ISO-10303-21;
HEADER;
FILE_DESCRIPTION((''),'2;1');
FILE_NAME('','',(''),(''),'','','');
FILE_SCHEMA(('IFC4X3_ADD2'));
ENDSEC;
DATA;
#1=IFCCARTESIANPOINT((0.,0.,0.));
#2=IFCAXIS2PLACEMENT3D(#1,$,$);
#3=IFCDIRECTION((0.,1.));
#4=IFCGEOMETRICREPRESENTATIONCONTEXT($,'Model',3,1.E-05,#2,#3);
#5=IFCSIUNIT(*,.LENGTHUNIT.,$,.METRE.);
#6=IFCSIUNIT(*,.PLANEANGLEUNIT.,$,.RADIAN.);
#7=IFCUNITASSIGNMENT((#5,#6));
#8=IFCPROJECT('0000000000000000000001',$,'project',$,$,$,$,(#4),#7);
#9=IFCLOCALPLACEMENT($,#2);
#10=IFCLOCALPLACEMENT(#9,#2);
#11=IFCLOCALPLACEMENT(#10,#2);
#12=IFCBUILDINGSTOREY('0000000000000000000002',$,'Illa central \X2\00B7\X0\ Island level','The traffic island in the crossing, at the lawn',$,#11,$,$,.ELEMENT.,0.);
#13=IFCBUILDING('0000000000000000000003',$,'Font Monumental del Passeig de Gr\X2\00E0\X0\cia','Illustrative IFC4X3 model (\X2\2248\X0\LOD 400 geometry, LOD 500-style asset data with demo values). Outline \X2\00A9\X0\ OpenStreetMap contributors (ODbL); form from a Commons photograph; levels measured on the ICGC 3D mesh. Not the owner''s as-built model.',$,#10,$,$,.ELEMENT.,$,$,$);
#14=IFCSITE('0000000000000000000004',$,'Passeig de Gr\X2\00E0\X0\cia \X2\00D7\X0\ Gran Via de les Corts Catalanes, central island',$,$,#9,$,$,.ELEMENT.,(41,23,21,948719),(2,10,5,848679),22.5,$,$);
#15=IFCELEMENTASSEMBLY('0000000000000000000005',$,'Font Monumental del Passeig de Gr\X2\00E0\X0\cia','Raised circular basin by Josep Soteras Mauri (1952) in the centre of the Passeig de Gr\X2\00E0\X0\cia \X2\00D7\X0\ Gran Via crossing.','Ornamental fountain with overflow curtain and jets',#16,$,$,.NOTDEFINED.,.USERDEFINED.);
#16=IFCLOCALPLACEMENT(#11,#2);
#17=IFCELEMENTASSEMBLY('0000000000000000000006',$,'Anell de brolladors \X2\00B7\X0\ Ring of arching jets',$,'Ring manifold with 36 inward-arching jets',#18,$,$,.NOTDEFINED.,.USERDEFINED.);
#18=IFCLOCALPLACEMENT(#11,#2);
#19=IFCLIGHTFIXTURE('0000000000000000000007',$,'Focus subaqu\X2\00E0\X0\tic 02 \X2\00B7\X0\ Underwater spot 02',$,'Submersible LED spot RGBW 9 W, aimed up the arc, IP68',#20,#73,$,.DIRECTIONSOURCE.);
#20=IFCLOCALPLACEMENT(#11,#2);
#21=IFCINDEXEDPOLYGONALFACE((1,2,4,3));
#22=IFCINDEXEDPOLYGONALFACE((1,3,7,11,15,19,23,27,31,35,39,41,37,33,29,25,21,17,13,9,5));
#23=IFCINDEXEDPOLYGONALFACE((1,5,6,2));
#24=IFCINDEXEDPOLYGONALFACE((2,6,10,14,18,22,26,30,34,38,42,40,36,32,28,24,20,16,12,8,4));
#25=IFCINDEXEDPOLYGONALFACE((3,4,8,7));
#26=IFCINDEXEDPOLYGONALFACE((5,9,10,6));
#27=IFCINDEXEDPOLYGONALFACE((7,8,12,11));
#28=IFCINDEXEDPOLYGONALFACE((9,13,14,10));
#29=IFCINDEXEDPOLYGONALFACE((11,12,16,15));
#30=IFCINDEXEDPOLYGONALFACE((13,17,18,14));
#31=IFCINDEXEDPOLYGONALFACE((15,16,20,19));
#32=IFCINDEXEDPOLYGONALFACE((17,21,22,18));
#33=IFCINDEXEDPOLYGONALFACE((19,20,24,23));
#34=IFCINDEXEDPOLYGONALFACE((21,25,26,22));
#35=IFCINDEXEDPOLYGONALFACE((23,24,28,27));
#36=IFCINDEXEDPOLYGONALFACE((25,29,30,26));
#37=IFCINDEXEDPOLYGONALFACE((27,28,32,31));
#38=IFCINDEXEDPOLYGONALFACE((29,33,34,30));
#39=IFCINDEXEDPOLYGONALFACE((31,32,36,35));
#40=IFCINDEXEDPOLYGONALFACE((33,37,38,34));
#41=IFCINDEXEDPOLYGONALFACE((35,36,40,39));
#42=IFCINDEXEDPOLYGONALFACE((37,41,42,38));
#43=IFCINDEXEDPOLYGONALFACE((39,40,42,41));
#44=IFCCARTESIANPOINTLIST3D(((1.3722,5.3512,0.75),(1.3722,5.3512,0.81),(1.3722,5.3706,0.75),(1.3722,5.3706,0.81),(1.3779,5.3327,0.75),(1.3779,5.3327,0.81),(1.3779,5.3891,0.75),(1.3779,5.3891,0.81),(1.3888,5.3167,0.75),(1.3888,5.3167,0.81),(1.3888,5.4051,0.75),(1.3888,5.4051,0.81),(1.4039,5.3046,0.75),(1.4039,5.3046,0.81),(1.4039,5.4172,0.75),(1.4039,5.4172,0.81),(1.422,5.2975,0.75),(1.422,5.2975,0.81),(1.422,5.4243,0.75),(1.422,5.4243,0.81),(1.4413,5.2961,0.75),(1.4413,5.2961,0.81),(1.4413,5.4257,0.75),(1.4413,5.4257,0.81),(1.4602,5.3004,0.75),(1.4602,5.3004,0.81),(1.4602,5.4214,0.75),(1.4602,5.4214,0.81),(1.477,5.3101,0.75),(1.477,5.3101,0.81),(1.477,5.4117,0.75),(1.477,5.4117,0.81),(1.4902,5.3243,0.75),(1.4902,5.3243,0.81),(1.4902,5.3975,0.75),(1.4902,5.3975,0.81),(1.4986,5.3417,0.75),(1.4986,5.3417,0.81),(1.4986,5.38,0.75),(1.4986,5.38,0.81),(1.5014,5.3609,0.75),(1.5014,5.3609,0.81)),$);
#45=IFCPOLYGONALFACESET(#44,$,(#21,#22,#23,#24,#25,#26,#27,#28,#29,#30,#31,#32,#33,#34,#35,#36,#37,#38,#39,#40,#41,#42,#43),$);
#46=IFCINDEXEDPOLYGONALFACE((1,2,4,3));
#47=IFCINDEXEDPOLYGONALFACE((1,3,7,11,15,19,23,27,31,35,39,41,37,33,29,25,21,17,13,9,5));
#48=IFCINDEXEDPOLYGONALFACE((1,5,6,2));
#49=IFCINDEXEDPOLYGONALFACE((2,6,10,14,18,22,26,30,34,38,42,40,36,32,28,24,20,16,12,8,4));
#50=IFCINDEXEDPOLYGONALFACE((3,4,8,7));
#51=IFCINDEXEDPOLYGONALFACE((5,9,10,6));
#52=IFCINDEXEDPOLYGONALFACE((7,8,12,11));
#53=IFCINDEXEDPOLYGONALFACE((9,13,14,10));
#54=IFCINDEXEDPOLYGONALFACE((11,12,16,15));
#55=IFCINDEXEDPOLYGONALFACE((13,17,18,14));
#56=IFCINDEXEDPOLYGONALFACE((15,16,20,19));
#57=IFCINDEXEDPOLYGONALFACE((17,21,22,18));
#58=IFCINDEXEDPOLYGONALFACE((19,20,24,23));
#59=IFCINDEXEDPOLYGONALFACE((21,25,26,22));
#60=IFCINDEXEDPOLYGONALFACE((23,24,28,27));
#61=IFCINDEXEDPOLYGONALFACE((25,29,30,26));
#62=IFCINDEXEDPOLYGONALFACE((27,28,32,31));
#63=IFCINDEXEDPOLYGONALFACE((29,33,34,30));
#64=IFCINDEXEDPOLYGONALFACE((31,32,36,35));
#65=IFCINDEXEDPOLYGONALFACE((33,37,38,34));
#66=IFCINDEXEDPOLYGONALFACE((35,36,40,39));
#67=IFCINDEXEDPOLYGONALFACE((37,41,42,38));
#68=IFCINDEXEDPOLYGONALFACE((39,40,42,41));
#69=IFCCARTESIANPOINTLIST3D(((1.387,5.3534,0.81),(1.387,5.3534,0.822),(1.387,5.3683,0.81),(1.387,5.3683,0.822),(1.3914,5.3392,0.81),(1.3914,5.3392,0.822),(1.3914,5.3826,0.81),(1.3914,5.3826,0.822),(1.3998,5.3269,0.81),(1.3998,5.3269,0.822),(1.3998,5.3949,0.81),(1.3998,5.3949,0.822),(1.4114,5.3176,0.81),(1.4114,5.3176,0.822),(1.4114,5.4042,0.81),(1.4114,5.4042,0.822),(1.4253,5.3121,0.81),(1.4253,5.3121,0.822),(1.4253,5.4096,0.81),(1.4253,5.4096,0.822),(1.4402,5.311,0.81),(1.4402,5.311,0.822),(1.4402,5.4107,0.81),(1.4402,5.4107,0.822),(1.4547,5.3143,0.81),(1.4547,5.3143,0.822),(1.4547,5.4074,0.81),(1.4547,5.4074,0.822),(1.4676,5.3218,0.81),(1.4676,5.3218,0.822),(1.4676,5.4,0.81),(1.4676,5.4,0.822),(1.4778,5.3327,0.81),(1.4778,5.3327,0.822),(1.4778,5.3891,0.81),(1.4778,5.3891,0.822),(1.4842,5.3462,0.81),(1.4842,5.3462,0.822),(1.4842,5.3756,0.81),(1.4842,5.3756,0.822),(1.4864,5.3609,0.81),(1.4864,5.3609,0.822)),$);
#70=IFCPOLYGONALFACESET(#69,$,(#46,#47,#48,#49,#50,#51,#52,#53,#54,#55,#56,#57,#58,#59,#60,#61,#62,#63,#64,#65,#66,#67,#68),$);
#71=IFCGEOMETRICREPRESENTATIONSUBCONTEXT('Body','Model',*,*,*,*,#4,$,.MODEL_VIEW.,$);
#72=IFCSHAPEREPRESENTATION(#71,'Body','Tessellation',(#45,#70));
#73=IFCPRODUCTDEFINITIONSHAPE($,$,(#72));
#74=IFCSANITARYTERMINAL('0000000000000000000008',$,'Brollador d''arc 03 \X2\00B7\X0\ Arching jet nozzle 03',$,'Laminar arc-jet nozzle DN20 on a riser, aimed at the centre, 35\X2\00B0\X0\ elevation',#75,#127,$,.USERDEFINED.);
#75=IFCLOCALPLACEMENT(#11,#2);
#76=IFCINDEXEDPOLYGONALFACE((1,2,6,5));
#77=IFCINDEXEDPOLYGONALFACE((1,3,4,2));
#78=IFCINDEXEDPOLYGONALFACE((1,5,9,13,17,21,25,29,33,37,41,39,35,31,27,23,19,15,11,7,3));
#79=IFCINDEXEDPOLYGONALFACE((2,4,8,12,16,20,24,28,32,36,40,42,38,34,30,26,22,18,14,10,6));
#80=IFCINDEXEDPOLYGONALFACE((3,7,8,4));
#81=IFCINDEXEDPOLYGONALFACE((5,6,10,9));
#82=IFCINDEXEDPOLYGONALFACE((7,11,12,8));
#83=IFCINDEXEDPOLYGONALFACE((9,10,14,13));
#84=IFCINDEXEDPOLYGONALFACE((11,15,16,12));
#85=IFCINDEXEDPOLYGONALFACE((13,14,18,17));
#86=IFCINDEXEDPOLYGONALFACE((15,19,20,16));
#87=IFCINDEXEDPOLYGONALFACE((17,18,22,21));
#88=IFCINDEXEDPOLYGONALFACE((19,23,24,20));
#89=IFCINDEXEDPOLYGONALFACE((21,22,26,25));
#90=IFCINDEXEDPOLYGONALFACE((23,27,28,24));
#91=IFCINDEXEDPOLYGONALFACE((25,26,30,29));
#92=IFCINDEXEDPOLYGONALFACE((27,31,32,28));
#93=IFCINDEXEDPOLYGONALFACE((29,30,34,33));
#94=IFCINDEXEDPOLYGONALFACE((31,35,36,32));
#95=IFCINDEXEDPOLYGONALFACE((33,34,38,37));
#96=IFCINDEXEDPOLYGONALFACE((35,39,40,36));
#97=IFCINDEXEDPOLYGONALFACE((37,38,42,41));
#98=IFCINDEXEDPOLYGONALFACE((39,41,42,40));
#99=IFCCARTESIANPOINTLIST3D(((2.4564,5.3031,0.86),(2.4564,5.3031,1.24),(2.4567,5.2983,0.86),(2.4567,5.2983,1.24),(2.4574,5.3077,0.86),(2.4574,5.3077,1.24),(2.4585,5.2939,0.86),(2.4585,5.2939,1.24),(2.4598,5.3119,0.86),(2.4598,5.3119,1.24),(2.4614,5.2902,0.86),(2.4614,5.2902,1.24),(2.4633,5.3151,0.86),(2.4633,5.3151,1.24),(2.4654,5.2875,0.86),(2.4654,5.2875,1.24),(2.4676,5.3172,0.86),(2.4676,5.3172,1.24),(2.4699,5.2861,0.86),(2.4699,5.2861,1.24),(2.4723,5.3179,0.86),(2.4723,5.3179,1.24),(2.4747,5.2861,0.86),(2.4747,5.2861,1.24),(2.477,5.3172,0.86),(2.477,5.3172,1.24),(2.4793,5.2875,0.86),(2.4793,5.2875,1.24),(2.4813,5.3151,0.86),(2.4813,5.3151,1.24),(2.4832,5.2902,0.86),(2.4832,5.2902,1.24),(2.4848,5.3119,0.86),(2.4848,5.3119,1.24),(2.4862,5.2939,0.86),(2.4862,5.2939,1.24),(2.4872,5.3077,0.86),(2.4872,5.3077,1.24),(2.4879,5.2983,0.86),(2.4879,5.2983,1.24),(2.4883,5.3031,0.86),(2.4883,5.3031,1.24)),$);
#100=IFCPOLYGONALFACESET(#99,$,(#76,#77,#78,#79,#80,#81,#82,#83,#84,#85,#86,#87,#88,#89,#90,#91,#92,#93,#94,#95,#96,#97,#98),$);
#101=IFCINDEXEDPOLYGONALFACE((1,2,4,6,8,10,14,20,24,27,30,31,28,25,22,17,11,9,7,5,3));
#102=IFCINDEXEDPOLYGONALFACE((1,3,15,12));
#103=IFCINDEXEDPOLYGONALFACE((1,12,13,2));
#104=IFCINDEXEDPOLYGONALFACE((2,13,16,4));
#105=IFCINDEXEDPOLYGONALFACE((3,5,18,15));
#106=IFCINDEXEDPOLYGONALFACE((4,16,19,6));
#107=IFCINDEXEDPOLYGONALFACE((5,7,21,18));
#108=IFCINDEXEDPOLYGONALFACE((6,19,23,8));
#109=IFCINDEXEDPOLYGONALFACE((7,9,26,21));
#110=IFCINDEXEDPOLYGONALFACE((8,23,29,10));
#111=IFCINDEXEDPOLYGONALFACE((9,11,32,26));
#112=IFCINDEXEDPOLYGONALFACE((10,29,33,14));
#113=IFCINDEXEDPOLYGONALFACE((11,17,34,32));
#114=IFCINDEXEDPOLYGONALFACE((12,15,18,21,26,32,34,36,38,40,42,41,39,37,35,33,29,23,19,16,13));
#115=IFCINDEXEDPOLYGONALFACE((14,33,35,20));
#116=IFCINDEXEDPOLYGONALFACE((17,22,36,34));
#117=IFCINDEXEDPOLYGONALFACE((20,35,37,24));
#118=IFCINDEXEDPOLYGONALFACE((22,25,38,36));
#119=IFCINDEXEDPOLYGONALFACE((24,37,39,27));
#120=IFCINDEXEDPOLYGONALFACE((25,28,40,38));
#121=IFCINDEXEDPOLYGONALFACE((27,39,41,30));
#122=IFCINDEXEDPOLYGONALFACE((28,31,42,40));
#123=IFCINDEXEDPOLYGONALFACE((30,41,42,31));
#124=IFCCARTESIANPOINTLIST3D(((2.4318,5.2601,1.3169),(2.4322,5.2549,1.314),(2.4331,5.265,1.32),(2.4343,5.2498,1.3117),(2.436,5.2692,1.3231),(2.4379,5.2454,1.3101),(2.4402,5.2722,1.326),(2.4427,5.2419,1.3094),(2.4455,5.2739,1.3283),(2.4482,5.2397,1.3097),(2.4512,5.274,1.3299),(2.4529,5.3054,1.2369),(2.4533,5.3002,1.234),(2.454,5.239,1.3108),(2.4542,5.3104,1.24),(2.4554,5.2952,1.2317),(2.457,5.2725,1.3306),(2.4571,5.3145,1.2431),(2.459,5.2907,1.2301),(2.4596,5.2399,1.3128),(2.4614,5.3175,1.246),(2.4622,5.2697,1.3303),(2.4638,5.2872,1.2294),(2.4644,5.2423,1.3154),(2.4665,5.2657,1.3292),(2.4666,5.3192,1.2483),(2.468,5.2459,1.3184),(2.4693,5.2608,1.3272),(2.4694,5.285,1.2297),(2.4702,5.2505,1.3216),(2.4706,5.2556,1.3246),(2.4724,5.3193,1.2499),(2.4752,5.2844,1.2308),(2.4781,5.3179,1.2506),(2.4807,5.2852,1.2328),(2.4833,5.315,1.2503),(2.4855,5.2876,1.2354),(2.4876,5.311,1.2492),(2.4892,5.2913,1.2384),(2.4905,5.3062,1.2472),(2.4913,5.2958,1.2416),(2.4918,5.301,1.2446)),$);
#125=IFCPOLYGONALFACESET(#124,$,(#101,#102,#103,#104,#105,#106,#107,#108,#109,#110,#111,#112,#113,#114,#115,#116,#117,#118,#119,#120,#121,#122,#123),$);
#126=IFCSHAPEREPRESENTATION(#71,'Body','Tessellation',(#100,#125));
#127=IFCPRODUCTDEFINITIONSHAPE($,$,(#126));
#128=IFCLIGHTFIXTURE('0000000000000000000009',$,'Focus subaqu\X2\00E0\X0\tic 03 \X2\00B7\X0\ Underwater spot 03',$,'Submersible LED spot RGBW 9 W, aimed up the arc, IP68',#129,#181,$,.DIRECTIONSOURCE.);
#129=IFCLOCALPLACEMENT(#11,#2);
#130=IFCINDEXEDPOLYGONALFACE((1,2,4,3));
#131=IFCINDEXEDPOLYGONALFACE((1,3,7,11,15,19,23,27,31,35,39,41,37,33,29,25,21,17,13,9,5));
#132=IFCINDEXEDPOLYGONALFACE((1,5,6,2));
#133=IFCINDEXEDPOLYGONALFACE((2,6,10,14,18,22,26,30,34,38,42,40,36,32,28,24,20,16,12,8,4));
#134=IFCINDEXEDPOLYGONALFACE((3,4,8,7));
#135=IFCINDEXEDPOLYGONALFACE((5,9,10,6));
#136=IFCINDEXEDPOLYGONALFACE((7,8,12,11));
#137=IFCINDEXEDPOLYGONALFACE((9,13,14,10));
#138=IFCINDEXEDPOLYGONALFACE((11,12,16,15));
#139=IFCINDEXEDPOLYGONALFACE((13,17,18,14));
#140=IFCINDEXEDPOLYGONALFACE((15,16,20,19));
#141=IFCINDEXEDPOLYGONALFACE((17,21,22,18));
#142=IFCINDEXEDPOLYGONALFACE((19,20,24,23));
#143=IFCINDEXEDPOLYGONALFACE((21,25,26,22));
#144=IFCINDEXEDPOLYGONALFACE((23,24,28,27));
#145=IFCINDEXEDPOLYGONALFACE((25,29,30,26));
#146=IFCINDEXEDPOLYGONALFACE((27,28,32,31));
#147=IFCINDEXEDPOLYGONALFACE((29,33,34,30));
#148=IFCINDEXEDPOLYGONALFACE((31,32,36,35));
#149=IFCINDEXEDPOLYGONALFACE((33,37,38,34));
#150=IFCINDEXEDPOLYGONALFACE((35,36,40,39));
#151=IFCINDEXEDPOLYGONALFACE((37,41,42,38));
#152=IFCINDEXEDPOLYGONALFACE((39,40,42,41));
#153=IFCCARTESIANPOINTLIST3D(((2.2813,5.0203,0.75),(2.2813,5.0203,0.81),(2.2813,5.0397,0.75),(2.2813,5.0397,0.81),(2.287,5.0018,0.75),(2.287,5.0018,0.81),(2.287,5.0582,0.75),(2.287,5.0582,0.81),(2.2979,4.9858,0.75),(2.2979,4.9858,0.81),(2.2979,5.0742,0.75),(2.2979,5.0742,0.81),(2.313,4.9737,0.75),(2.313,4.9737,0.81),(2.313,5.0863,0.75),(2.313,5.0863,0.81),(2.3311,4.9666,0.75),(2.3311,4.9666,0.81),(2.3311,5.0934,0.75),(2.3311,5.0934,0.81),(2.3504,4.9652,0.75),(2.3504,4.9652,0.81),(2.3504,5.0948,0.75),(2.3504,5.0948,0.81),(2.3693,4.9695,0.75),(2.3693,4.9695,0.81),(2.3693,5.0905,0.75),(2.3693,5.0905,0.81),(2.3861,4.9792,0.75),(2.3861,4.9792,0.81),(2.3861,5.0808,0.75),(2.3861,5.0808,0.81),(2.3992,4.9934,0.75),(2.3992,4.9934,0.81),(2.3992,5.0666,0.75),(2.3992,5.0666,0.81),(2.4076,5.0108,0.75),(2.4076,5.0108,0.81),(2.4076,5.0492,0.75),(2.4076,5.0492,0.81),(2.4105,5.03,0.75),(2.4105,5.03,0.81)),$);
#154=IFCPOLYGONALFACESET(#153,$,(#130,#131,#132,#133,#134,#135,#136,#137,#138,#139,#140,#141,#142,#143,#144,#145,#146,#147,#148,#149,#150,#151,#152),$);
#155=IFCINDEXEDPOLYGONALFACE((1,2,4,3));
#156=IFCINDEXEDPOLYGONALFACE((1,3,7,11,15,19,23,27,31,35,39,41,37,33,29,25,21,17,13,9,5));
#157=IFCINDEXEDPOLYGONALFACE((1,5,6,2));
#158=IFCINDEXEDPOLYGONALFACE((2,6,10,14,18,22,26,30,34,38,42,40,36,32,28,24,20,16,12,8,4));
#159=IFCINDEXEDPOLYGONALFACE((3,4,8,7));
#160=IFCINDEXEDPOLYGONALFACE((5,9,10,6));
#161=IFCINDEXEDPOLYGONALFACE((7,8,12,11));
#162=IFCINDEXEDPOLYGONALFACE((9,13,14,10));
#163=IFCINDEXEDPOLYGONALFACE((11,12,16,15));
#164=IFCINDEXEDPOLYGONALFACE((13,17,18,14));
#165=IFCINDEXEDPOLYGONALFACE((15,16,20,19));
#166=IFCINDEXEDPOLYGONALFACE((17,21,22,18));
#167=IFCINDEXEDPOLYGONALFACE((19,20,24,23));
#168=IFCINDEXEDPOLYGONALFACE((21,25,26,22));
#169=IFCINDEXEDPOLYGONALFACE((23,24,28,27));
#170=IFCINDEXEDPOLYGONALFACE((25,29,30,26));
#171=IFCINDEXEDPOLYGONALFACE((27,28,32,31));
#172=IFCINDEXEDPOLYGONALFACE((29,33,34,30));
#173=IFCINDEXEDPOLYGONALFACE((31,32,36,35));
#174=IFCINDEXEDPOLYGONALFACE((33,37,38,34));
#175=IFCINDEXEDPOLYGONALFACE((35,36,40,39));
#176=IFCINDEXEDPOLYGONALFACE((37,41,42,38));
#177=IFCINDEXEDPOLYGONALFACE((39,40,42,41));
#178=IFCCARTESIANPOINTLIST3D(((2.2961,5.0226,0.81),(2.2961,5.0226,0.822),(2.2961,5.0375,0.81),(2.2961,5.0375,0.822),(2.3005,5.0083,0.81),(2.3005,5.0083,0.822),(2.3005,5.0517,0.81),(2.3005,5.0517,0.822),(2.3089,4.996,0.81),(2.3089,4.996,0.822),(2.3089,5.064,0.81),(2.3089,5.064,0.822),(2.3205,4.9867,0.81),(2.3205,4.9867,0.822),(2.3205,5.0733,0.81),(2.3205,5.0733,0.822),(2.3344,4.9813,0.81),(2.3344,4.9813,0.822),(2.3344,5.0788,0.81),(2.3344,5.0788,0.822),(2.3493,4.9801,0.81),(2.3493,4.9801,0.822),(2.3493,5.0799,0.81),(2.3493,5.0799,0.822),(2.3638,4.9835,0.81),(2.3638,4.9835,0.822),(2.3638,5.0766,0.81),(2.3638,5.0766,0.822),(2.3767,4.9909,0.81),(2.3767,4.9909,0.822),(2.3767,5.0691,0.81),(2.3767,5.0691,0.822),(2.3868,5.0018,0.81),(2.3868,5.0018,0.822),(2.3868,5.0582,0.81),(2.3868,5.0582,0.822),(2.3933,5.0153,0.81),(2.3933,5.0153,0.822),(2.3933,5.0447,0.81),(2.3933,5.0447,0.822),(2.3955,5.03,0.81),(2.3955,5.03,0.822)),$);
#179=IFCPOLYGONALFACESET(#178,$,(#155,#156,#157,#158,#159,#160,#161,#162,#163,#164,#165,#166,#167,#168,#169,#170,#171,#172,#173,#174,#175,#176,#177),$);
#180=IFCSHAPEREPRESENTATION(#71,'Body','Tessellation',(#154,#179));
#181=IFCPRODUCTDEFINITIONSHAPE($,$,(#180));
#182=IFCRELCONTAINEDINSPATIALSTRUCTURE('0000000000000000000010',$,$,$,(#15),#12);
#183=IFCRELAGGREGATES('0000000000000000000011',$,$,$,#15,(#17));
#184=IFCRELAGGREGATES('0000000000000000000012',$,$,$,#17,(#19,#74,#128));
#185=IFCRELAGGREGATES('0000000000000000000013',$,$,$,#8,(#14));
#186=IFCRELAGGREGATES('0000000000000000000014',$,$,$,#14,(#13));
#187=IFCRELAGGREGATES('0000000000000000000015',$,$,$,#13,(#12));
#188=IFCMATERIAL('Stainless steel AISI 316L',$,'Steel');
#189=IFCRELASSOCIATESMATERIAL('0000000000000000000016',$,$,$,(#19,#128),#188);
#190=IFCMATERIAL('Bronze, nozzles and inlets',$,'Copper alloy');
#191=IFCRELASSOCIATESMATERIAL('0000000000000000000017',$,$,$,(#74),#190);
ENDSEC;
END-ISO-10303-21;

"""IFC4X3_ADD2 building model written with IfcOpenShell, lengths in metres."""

from ifc_helpers import new_model, si_unit, direction, frame, origin, origin_2d_with_axis, place, context, subcontext, project, spatial, circle, extrude, material, element, aggregate, save


model = new_model("IFC4X3_ADD2")

# Units and contexts
model_context = context("Model", 3, precision=1e-05, world=origin(), true_north=direction((0.0, 1.0)))
body_context = subcontext(model_context, "Body", "Model", "MODEL_VIEW")
ifc_project = project(units=[si_unit("LENGTHUNIT", "METRE"), si_unit("PLANEANGLEUNIT", "RADIAN")], contexts=[model_context])

# Site, building, storey
site_placement = place(None, origin())
site = spatial("IfcSite", under=ifc_project, at=site_placement, Name="Passeig de Gràcia × Gran Via de les Corts Catalanes, central island", CompositionType="ELEMENT", RefLatitude=(41, 23, 21, 948719), RefLongitude=(2, 10, 5, 848679), RefElevation=22.5)
building_placement = place(site_placement, origin())
building = spatial("IfcBuilding", under=site, at=building_placement, Name="Font Monumental del Passeig de Gràcia", Description="Illustrative IFC4X3 model (≈LOD 400 geometry, LOD 500-style asset data with demo values). Outline © OpenStreetMap contributors (ODbL); form from a Commons photograph; levels measured on the ICGC 3D mesh. Not the owner's as-built model.", CompositionType="ELEMENT")
storey_placement = place(building_placement, origin())
storey = spatial("IfcBuildingStorey", under=building, at=storey_placement, Name="Illa central · Island level", Description="The traffic island in the crossing, at the lawn", CompositionType="ELEMENT", Elevation=0.0)

# Element assemblies, light fixtures, sanitary terminal
assembly_1_placement = place(building_placement, origin())
assembly_1 = element("IfcElementAssembly", 1, at=assembly_1_placement, inside=storey, Name="Font Monumental del Passeig de Gràcia", Description="Raised circular basin by Josep Soteras Mauri (1952) in the centre of the Passeig de Gràcia × Gran Via crossing.", ObjectType="Ornamental fountain with overflow curtain and jets", AssemblyPlace="NOTDEFINED", PredefinedType="USERDEFINED")
ifc_material_1 = material(Name="Bronze, nozzles and inlets", Category="Copper alloy")
ifc_material_2 = material(Name="Stainless steel AISI 316L", Category="Steel")
assembly_2_placement = place(building_placement, origin())
assembly_2 = element("IfcElementAssembly", 2, at=assembly_2_placement, Name="Anell de brolladors · Ring of arching jets", ObjectType="Ring manifold with 36 inward-arching jets", AssemblyPlace="NOTDEFINED", PredefinedType="USERDEFINED")
light_fixture_1_placement = place(building_placement, origin())
light_fixture_1 = element("IfcLightFixture", 3, at=light_fixture_1_placement, material=ifc_material_2, Name="Focus subaquàtic 02 · Underwater spot 02", ObjectType="Submersible LED spot RGBW 9 W, aimed up the arc, IP68", PredefinedType="DIRECTIONSOURCE", context=body_context, shape_type="SweptSolid", body=[
    extrude(circle(Radius=0.065, at=origin_2d_with_axis()), frame((1.4364, 5.3609, 0.75)), (0.0, 0.0, 1.0), 0.06),
    extrude(circle(Radius=0.05, at=origin_2d_with_axis()), frame((1.4364, 5.3609, 0.81)), (0.0, 0.0, 1.0), 0.012),
])
sanitary_terminal_1_placement = place(building_placement, origin())
sanitary_terminal_1 = element("IfcSanitaryTerminal", 4, at=sanitary_terminal_1_placement, material=ifc_material_1, Name="Brollador d'arc 03 · Arching jet nozzle 03", ObjectType="Laminar arc-jet nozzle DN20 on a riser, aimed at the centre, 35° elevation", PredefinedType="USERDEFINED", context=body_context, shape_type="SweptSolid", body=[
    extrude(circle(Radius=0.016, at=origin_2d_with_axis()), frame((2.4723, 5.3019, 0.86), z_axis=(0.0, 0.0, 1.0), x_axis=(0.0, 1.0, 0.0)), (0.0, 0.0, 1.0), 0.38),
    extrude(circle(Radius=0.02, at=origin_2d_with_axis()), frame((2.4723, 5.3019, 1.24), z_axis=(-0.223987, -0.480342, 0.847998), x_axis=(-0.906308, 0.422618, 0.0)), (0.0, 0.0, 1.0), 0.0943),
])
light_fixture_2_placement = place(building_placement, origin())
light_fixture_2 = element("IfcLightFixture", 5, at=light_fixture_2_placement, material=ifc_material_2, Name="Focus subaquàtic 03 · Underwater spot 03", ObjectType="Submersible LED spot RGBW 9 W, aimed up the arc, IP68", PredefinedType="DIRECTIONSOURCE", context=body_context, shape_type="SweptSolid", body=[
    extrude(circle(Radius=0.065, at=origin_2d_with_axis()), frame((2.3455, 5.03, 0.75)), (0.0, 0.0, 1.0), 0.06),
    extrude(circle(Radius=0.05, at=origin_2d_with_axis()), frame((2.3455, 5.03, 0.81)), (0.0, 0.0, 1.0), 0.012),
])
aggregate(assembly_1, [assembly_2])
aggregate(assembly_2, [light_fixture_1, sanitary_terminal_1, light_fixture_2])

save(model, "model.ifc")
